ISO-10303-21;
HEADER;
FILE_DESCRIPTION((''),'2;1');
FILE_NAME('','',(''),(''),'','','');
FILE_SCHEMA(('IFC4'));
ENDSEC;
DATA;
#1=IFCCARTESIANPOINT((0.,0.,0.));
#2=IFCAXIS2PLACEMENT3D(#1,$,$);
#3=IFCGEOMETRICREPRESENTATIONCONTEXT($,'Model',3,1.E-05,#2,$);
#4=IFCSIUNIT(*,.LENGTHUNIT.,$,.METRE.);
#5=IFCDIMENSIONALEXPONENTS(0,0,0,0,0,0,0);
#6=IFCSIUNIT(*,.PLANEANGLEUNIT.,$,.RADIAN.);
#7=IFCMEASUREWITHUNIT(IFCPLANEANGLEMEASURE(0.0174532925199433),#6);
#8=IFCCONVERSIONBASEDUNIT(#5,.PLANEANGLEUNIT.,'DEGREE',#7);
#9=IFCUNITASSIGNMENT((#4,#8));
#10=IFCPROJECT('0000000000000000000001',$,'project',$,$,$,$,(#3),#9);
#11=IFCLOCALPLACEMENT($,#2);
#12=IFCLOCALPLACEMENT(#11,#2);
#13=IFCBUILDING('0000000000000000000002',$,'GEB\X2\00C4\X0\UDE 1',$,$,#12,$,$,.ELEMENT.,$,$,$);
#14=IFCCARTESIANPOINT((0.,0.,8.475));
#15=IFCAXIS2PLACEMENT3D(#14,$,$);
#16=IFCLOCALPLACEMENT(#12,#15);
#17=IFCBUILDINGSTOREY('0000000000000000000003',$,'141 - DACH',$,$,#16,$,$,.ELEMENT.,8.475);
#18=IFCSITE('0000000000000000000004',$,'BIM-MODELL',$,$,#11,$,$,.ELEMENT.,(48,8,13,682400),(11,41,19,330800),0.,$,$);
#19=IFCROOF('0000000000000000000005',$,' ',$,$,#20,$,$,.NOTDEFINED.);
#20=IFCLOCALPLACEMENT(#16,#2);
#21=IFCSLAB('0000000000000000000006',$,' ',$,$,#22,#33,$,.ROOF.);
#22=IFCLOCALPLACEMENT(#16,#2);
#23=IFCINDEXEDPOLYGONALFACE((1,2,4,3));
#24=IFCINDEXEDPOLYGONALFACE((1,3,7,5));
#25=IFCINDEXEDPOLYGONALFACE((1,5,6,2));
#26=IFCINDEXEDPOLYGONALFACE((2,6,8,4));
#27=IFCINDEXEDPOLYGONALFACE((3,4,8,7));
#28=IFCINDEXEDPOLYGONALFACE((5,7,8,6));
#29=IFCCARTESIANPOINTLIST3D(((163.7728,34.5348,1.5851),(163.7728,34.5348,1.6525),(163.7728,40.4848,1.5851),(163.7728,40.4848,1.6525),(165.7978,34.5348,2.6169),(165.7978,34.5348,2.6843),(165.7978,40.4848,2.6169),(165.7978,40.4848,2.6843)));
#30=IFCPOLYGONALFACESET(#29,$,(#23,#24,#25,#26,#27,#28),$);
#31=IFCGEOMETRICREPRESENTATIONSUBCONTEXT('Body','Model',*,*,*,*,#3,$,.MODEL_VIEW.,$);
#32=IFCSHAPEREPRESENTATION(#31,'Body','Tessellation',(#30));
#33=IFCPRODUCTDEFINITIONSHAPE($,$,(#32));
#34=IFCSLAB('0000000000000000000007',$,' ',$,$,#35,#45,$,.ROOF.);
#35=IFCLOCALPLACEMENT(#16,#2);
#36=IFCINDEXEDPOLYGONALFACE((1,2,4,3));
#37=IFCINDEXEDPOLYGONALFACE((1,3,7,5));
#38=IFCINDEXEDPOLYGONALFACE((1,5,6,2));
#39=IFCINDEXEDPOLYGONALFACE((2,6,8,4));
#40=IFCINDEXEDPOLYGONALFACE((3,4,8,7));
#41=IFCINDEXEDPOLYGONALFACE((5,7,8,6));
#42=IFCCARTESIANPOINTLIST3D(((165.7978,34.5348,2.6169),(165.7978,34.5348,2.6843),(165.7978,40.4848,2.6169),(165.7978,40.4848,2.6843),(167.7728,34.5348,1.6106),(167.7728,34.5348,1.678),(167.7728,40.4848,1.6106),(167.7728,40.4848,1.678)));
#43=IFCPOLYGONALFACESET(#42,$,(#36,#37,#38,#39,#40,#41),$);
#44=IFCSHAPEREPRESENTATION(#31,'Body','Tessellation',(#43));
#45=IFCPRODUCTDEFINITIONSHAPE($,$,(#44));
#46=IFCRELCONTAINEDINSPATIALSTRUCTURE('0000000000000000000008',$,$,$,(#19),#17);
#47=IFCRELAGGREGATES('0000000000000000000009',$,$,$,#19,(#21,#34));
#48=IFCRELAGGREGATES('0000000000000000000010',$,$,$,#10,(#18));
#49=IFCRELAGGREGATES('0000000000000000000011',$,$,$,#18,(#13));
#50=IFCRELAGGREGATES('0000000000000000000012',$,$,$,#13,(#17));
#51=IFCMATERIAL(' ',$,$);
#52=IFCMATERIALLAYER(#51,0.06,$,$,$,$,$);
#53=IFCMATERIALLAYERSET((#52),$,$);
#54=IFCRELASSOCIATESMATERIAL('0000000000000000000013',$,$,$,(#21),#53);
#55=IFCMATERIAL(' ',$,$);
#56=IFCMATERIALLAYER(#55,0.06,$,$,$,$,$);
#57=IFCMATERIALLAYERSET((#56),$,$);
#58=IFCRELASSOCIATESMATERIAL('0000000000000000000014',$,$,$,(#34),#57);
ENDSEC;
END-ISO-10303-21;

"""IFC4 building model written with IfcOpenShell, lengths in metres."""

from ifc_helpers import new_model, entity, si_unit, converted_unit, frame, frame_2d, origin, origin_2d_with_axis, place, context, subcontext, project, spatial, rectangle, extrude, material, layer, layer_set, layer_usage, element, aggregate, save


model = new_model("IFC4")

# Units and contexts
model_context = context("Model", 3, precision=1e-05, world=origin())
body_context = subcontext(model_context, "Body", "Model", "MODEL_VIEW")
ifc_project = project(units=[si_unit("LENGTHUNIT", "METRE"), converted_unit("PLANEANGLEUNIT", "DEGREE", entity("IfcPlaneAngleMeasure", 0.0174532925199433), si_unit("PLANEANGLEUNIT", "RADIAN"), dimensions=[0, 0, 0, 0, 0, 0, 0])], contexts=[model_context])

# Site, building, storey
site_placement = place(None, origin())
site = spatial("IfcSite", under=ifc_project, at=site_placement, Name="BIM-MODELL", CompositionType="ELEMENT", RefLatitude=(48, 8, 13, 682400), RefLongitude=(11, 41, 19, 330800), RefElevation=0.0)
building_placement = place(site_placement, origin())
building = spatial("IfcBuilding", under=site, at=building_placement, Name="GEBÄUDE 1", CompositionType="ELEMENT")
storey_placement = place(building_placement, frame((0.0, 0.0, 8.475)))
storey = spatial("IfcBuildingStorey", under=building, at=storey_placement, Name="141 - DACH", CompositionType="ELEMENT", Elevation=8.475)

# Roof, slabs
roof_placement = place(storey_placement, frame((0.0, 0.0, -8.475)))
roof = element("IfcRoof", 1, at=roof_placement, inside=storey, Name=" ", PredefinedType="NOTDEFINED")
ifc_material_1 = material(Name=" ")
ifc_layer_1 = layer(ifc_material_1, 0.06)
ifc_layer_set_1 = layer_set([ifc_layer_1])
ifc_layer_usage_1 = layer_usage(ifc_layer_set_1, "AXIS3", "POSITIVE", 0.0)
slab_1_placement = place(roof_placement, frame((163.7728, 34.5348, 10.0601)))
slab_1 = element("IfcSlab", 2, at=slab_1_placement, material=ifc_layer_usage_1, Name=" ", PredefinedType="ROOF", context=body_context, shape_type="SweptSolid", body=[
    extrude(rectangle(XDim=5.95, YDim=2.2727, at=origin_2d_with_axis()), frame((1.0125, 2.975, 0.5159), z_axis=(-0.45399, 0.0, 0.891007), x_axis=(0.0, 1.0, 0.0)), (0.0, -0.45399, 0.891007), 0.0673),
])
ifc_material_2 = material(Name=" ")
ifc_layer_2 = layer(ifc_material_2, 0.06)
ifc_layer_set_2 = layer_set([ifc_layer_2])
ifc_layer_usage_2 = layer_usage(ifc_layer_set_2, "AXIS3", "POSITIVE", 0.0)
slab_2_placement = place(roof_placement, frame((165.7978, 34.5348, 10.0856)))
slab_2 = element("IfcSlab", 3, at=slab_2_placement, material=ifc_layer_usage_2, Name=" ", PredefinedType="ROOF", context=body_context, shape_type="SweptSolid", body=[
    extrude(rectangle(XDim=2.2166, YDim=5.95, at=frame_2d((0.0, 0.0), x_axis=(0.0, 1.0))), frame((0.9875, 2.975, 0.5032), z_axis=(0.45399, 0.0, 0.891007), x_axis=(0.0, -1.0, 0.0)), (0.0, -0.45399, 0.891007), 0.0673),
])
aggregate(roof, [slab_1, slab_2])

save(model, "model.ifc")
